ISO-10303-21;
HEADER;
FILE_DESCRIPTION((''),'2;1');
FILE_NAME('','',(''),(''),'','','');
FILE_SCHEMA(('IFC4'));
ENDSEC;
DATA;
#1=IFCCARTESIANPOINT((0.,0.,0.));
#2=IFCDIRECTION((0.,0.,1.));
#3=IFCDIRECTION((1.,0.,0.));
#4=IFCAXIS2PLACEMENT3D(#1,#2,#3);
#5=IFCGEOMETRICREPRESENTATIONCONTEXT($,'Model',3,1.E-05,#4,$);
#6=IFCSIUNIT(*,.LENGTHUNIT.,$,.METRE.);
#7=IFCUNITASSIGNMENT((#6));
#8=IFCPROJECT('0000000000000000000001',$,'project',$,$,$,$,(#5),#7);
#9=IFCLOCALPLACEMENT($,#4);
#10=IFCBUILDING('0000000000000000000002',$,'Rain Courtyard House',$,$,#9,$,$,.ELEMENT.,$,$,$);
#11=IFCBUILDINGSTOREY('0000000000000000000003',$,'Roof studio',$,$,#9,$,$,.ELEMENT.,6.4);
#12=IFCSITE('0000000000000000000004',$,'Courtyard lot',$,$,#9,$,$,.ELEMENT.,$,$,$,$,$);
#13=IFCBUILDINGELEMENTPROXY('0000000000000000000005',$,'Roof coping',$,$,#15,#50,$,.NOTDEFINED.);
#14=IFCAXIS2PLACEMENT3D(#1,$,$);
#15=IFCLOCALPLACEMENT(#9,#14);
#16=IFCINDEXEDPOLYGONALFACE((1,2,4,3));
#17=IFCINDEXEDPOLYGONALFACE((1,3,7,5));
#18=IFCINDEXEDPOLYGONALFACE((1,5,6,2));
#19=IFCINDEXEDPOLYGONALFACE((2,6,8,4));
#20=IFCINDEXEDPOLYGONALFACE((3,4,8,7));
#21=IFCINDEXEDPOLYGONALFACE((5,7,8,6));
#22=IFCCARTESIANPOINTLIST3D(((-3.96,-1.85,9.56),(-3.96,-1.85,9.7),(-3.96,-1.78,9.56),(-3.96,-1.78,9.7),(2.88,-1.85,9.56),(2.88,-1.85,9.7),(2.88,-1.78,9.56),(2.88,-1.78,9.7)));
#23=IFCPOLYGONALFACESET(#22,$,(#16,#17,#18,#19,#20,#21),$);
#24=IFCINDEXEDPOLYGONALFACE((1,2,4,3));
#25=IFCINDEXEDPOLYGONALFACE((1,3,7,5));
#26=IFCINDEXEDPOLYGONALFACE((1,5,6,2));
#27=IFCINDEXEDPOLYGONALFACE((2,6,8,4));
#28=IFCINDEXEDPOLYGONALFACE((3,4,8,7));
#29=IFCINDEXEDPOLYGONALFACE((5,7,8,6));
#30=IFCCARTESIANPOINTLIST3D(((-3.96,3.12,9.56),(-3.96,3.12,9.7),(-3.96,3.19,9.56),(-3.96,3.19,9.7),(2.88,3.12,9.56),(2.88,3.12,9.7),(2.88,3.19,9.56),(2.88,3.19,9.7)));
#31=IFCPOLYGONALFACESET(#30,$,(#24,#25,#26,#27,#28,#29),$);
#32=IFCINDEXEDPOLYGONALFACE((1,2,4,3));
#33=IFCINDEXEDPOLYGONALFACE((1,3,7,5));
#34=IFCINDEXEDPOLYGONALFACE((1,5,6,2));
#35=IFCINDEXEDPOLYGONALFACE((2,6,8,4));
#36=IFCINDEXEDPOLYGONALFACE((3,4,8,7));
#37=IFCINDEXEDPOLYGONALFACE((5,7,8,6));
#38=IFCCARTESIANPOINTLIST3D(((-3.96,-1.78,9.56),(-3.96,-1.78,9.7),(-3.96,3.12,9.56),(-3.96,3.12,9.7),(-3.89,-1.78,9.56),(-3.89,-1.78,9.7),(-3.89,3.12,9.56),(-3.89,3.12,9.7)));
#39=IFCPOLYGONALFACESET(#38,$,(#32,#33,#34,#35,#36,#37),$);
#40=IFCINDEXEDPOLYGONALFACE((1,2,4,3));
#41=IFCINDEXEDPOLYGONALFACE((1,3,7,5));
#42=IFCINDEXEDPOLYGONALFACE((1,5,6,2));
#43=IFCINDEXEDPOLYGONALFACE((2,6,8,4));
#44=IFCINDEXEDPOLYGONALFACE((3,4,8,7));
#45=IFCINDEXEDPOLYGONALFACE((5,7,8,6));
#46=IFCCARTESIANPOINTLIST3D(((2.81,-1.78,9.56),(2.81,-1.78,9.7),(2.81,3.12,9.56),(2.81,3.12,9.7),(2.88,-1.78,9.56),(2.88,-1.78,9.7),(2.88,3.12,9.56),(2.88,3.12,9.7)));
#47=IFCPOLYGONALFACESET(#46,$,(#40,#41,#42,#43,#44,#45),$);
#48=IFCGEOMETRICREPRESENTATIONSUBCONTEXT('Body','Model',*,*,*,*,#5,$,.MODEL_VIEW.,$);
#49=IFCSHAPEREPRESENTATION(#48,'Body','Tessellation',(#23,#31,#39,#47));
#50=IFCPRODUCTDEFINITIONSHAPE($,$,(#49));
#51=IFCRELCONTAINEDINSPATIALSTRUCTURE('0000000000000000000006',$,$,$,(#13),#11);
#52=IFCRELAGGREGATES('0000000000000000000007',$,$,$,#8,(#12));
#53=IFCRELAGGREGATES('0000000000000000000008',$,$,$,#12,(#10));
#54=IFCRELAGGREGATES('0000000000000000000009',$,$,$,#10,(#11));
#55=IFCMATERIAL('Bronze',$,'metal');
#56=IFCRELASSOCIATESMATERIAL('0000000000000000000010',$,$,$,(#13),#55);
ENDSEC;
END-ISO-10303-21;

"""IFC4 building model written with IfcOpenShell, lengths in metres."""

from ifc_helpers import new_model, si_unit, frame, origin_with_axes, origin_2d, place, context, subcontext, project, spatial, rectangle, extrude, material, element, save


model = new_model("IFC4")

# Units and contexts
model_context = context("Model", 3, precision=1e-05, world=origin_with_axes())
body_context = subcontext(model_context, "Body", "Model", "MODEL_VIEW")
ifc_project = project(units=[si_unit("LENGTHUNIT", "METRE")], contexts=[model_context])

# Site, building, storey
placement = place(None, origin_with_axes())
site = spatial("IfcSite", under=ifc_project, at=placement, Name="Courtyard lot", CompositionType="ELEMENT")
building = spatial("IfcBuilding", under=site, at=placement, Name="Rain Courtyard House", CompositionType="ELEMENT")
storey = spatial("IfcBuildingStorey", under=building, at=placement, Name="Roof studio", CompositionType="ELEMENT", Elevation=6.4)

# Building element proxy
ifc_material_1 = material(Name="Bronze", Category="metal")
element("IfcBuildingElementProxy", 1, at=placement, inside=storey, material=ifc_material_1, Name="Roof coping", PredefinedType="NOTDEFINED", context=body_context, shape_type="SweptSolid", body=[
    extrude(rectangle(XDim=6.84, YDim=0.07, at=origin_2d()), frame((-0.54, -1.815, 9.56), z_axis=(0.0, 0.0, 1.0), x_axis=(1.0, 0.0, 0.0)), (0.0, 0.0, 1.0), 0.14),
    extrude(rectangle(XDim=6.84, YDim=0.07, at=origin_2d()), frame((-0.54, 3.155, 9.56), z_axis=(0.0, 0.0, 1.0), x_axis=(1.0, 0.0, 0.0)), (0.0, 0.0, 1.0), 0.14),
    extrude(rectangle(XDim=0.07, YDim=4.9, at=origin_2d()), frame((-3.925, 0.67, 9.56), z_axis=(0.0, 0.0, 1.0), x_axis=(1.0, 0.0, 0.0)), (0.0, 0.0, 1.0), 0.14),
    extrude(rectangle(XDim=0.07, YDim=4.9, at=origin_2d()), frame((2.845, 0.67, 9.56), z_axis=(0.0, 0.0, 1.0), x_axis=(1.0, 0.0, 0.0)), (0.0, 0.0, 1.0), 0.14),
])

save(model, "model.ifc")
